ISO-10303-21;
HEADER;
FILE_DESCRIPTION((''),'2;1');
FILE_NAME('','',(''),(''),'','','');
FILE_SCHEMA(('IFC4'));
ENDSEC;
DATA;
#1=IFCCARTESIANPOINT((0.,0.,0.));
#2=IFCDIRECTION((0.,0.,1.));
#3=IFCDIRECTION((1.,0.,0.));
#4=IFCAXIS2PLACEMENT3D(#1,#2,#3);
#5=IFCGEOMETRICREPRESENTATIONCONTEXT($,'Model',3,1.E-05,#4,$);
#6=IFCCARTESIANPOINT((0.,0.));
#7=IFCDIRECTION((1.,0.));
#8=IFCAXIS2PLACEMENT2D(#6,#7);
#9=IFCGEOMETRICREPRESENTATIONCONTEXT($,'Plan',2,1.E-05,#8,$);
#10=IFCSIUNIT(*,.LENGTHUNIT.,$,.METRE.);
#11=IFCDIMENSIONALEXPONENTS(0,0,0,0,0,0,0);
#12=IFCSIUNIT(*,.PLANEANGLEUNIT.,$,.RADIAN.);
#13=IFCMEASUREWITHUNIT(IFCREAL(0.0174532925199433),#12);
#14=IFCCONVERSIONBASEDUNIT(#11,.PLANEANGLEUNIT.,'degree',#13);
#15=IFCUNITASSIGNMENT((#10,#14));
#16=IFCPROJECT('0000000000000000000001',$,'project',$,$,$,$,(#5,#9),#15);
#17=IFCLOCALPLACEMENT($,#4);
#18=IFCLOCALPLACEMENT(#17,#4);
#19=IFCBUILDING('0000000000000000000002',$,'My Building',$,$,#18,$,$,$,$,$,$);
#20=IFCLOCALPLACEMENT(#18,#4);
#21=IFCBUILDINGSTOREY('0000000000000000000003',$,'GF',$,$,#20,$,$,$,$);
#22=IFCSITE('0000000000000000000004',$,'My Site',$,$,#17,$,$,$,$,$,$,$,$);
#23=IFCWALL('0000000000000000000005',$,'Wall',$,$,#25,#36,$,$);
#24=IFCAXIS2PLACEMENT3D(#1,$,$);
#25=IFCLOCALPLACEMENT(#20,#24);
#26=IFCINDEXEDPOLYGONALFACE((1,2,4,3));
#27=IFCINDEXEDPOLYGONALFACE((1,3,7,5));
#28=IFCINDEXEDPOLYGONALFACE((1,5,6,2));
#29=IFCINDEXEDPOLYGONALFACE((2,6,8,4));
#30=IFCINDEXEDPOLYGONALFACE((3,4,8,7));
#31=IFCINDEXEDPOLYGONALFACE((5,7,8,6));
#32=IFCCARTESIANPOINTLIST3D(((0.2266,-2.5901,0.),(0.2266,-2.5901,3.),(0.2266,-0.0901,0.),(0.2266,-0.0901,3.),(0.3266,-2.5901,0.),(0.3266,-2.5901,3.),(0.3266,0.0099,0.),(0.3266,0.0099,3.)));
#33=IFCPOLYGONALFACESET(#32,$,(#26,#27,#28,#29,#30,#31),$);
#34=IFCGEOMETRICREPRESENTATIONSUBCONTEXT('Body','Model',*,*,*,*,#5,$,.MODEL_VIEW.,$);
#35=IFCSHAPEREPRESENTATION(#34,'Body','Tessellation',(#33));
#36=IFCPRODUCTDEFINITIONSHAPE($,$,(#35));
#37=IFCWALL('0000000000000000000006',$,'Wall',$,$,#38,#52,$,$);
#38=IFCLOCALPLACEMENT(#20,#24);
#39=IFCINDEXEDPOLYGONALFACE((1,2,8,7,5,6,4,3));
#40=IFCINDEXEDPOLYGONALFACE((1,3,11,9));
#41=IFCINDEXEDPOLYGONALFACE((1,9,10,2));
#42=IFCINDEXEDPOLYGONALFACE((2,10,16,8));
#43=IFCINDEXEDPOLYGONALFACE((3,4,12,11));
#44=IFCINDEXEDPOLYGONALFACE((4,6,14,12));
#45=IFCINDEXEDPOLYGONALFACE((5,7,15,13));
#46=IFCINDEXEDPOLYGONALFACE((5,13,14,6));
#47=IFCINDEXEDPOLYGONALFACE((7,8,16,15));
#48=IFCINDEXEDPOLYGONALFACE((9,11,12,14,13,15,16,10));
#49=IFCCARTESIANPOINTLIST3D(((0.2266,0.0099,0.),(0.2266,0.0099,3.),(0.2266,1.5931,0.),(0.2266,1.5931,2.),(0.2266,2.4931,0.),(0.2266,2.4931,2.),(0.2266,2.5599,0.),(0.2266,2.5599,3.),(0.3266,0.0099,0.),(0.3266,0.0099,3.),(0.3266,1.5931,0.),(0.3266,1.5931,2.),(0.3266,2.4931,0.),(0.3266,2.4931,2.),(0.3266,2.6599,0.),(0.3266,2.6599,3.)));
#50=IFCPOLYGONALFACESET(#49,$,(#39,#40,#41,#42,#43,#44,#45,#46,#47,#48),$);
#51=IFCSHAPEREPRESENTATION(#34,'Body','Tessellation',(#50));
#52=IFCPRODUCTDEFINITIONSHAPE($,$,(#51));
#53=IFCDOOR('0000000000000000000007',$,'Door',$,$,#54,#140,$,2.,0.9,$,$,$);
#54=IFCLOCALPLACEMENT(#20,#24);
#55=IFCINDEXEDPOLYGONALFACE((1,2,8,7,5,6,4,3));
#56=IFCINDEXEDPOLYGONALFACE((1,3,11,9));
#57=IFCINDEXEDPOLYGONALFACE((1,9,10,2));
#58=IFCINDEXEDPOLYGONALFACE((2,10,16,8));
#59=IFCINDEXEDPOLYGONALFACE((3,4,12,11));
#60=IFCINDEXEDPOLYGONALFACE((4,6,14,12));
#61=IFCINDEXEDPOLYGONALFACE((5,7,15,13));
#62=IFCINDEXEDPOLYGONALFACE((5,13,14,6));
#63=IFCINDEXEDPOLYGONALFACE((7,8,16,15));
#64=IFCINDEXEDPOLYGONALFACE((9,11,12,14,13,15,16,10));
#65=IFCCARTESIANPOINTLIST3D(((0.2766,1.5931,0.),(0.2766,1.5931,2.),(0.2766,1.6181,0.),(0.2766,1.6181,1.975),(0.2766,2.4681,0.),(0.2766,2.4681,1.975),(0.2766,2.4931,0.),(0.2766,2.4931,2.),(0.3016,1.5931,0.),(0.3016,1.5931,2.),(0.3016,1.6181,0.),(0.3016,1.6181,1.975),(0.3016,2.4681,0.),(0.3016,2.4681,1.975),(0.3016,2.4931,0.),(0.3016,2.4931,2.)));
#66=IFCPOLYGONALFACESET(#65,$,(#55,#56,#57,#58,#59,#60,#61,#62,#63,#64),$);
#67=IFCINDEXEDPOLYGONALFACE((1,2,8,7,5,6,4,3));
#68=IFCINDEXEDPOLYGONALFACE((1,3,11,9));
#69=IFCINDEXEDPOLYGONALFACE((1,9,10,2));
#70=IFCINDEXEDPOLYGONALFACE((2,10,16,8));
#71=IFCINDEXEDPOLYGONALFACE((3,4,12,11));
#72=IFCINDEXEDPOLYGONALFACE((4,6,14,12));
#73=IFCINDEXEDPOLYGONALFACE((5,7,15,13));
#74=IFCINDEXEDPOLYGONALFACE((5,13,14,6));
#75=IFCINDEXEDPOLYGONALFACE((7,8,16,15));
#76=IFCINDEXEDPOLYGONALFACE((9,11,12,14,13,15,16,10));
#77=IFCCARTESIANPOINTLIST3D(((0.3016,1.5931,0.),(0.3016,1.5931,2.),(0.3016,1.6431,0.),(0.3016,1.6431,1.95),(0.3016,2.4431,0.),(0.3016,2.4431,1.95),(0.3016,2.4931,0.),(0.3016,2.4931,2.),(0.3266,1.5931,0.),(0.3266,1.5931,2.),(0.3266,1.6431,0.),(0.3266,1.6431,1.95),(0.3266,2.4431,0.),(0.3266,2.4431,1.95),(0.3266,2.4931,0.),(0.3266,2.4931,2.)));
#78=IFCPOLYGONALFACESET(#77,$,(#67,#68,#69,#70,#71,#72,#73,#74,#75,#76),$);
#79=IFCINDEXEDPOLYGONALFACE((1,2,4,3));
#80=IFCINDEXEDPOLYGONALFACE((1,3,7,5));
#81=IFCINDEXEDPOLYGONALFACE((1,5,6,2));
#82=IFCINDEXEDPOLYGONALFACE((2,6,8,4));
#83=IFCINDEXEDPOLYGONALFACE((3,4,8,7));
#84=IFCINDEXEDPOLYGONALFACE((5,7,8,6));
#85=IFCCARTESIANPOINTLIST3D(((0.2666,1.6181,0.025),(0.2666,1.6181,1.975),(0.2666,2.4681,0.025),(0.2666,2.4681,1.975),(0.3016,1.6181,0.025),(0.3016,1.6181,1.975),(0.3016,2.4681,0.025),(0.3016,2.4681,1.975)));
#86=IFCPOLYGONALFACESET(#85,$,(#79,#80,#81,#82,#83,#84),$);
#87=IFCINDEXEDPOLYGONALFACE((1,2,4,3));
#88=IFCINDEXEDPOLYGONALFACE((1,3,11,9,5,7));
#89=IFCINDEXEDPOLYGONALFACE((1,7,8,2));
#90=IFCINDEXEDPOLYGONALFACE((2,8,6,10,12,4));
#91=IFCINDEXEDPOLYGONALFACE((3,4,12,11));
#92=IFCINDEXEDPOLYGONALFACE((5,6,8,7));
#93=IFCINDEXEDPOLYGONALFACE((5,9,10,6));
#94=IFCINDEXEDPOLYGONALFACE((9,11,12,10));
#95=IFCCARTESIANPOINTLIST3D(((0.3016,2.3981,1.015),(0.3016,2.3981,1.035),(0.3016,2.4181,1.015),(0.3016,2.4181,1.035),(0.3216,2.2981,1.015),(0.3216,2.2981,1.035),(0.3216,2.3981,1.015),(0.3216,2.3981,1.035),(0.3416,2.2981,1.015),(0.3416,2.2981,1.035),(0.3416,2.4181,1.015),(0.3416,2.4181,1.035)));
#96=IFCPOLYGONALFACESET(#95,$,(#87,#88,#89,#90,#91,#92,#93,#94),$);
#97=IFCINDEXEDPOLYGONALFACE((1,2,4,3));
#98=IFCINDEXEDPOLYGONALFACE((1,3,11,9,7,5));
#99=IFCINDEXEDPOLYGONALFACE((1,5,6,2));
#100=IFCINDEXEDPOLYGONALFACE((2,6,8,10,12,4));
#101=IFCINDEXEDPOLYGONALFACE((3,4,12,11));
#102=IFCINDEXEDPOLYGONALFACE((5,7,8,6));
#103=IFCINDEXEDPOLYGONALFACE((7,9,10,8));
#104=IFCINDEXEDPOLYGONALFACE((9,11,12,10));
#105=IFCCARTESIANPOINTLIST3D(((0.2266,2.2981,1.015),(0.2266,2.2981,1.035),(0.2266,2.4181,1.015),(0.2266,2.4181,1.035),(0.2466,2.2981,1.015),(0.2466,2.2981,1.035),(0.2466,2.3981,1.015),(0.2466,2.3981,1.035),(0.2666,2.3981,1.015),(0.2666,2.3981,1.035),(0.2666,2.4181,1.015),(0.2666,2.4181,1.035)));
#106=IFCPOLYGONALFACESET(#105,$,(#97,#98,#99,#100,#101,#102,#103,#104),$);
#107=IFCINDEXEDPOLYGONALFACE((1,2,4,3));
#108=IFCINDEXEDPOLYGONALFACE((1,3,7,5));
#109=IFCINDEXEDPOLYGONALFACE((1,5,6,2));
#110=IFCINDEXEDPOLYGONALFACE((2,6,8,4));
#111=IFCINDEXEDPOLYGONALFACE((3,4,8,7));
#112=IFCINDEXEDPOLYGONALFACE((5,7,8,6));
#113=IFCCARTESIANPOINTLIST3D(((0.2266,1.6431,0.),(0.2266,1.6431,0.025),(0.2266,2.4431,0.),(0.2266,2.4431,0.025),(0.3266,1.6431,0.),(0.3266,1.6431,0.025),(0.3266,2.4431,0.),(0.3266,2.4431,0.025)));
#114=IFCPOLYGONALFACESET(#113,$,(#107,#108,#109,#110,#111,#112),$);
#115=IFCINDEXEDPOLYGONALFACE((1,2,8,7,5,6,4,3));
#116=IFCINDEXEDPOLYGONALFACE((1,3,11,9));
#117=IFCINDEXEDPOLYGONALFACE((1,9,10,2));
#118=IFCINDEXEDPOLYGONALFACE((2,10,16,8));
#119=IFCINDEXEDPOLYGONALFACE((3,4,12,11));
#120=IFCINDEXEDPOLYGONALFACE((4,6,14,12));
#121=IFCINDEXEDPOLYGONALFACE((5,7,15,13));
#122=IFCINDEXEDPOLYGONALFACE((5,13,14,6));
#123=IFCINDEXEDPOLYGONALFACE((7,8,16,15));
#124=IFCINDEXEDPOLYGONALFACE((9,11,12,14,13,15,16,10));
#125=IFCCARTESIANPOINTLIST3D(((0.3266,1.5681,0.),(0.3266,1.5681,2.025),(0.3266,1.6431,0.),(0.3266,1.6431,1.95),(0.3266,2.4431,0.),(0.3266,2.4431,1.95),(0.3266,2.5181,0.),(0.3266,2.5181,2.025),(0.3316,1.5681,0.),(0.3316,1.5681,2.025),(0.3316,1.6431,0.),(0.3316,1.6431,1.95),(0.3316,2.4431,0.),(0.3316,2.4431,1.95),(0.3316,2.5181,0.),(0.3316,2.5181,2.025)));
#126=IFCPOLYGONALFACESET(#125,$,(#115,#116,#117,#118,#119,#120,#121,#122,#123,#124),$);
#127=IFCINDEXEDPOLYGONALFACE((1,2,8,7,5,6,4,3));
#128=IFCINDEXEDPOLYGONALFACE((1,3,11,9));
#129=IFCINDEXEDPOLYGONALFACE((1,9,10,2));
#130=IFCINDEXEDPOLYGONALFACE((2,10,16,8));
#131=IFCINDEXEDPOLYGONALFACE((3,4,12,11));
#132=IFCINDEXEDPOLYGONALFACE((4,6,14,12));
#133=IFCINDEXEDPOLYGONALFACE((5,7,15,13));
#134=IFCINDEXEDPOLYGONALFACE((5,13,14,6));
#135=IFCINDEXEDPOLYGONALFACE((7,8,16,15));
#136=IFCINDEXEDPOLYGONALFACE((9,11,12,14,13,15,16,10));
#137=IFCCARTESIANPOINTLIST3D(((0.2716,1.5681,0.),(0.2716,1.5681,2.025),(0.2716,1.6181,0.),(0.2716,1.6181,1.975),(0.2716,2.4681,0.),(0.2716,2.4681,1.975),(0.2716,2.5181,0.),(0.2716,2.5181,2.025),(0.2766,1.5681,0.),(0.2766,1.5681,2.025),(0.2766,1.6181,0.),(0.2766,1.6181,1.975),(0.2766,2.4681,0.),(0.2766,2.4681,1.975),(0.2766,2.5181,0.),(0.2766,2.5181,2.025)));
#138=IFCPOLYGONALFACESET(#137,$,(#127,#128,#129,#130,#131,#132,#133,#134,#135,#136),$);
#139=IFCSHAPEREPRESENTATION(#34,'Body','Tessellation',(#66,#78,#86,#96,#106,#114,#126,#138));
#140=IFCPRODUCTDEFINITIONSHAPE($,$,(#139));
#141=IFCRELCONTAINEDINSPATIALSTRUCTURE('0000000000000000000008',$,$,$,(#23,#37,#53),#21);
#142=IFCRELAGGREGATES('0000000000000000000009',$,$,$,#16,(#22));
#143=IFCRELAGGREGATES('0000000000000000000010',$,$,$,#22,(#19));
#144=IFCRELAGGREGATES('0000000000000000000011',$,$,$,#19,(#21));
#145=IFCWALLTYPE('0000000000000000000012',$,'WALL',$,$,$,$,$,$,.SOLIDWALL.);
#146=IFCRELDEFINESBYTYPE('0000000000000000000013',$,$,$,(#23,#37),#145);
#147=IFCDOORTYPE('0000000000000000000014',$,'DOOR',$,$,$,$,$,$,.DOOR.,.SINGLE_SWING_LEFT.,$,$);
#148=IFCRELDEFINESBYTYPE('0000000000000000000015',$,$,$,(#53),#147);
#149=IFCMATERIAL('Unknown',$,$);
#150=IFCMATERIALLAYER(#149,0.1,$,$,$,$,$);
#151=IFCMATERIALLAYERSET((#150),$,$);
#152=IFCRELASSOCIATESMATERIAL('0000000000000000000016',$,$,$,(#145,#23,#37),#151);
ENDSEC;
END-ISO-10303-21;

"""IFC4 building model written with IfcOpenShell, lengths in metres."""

from ifc_helpers import new_model, entity, si_unit, converted_unit, frame, origin_with_axes, origin_2d_with_axis, place, context, subcontext, project, spatial, line, indexed_curve, outline, extrude, shape, source, transform, mapped, material, layer, layer_set, layer_usage, type_object, type_shapes, element, fill, save


model = new_model("IFC4")

# Units and contexts
model_context = context("Model", 3, precision=1e-05, world=origin_with_axes())
plan_context = context("Plan", 2, precision=1e-05, world=origin_2d_with_axis())
body_context_1 = subcontext(model_context, "Body", "Model", "MODEL_VIEW")
body_context_2 = subcontext(plan_context, "Body", "Plan", "PLAN_VIEW")
ifc_project = project(units=[si_unit("LENGTHUNIT", "METRE"), converted_unit("PLANEANGLEUNIT", "degree", entity("IfcReal", 0.0174532925199433), si_unit("PLANEANGLEUNIT", "RADIAN"), dimensions=[0, 0, 0, 0, 0, 0, 0])], contexts=[model_context, plan_context])

# Site, building, storey
site_placement = place(None, origin_with_axes())
site = spatial("IfcSite", under=ifc_project, at=site_placement, Name="My Site")
building_placement = place(site_placement, origin_with_axes())
building = spatial("IfcBuilding", under=site, at=building_placement, Name="My Building")
storey_placement = place(building_placement, origin_with_axes())
storey = spatial("IfcBuildingStorey", under=building, at=storey_placement, Name="GF")

# Shared definitions
ifc_material = material(Name="Unknown")

# Shared definitions
ifc_layer_1 = layer(ifc_material, 0.1)
ifc_layer_set_1 = layer_set([ifc_layer_1])
wall_type = type_object("IfcWallType", Name="WALL", PredefinedType="SOLIDWALL", material=ifc_layer_set_1)
shared_shape_1 = source(origin_with_axes(), body_context_1, "Body", "SweptSolid", [
    extrude(outline(indexed_curve([(0.0, 0.0), (0.9, 0.0), (0.9, 2.0), (0.0, 2.0)], segments=[line(1, 2, 3, 4, 1)])), frame((0.0, -0.6, 0.0), z_axis=(0.0, -1.0, 0.0), x_axis=(1.0, 0.0, 0.0)), (0.0, 0.0, -1.0), 1.2),
])
door_type = type_object("IfcDoorType", Name="DOOR", OperationType="SINGLE_SWING_LEFT", PredefinedType="DOOR")
shared_shape_2 = source(origin_with_axes(), body_context_1, "Body", "SweptSolid", [
    extrude(outline(indexed_curve([(0.0, 0.0), (0.0, 2.0), (0.9, 2.0), (0.9, 0.0), (0.875, 0.0), (0.875, 1.975), (0.025, 1.975), (0.025, 0.0)], segments=[line(1, 2, 3, 4, 5, 6, 7, 8, 1)])), frame((0.0, 0.025, 0.0), z_axis=(0.0, -1.0, 0.0), x_axis=(1.0, 0.0, 0.0)), (0.0, 0.0, -1.0), 0.025),
    extrude(outline(indexed_curve([(0.0, 0.0), (0.0, 2.0), (0.9, 2.0), (0.9, 0.0), (0.85, 0.0), (0.85, 1.95), (0.05, 1.95), (0.05, 0.0)], segments=[line(1, 2, 3, 4, 5, 6, 7, 8, 1)])), frame((0.0, 0.0, 0.0), z_axis=(0.0, -1.0, 0.0), x_axis=(1.0, 0.0, 0.0)), (0.0, 0.0, -1.0), 0.025),
    extrude(outline(indexed_curve([(0.0, 0.0), (0.85, 0.0), (0.85, 0.035), (0.0, 0.035)], segments=[line(1, 2, 3, 4, 1)])), frame((0.025, 0.025, 0.025), z_axis=(0.0, 0.0, 1.0), x_axis=(1.0, 0.0, 0.0)), (0.0, 0.0, 1.0), 1.95),
    extrude(outline(indexed_curve([(0.0, 0.0), (0.0, -0.04), (-0.12, -0.04), (-0.12, -0.02), (-0.02, -0.02), (-0.02, 0.0)], segments=[line(1, 2, 3, 4, 5, 6, 1)])), frame((0.825, 0.025, 1.015), z_axis=(0.0, 0.0, 1.0), x_axis=(1.0, 0.0, 0.0)), (0.0, 0.0, 1.0), 0.02),
    extrude(outline(indexed_curve([(0.0, 0.0), (0.0, 0.04), (-0.12, 0.04), (-0.12, 0.02), (-0.02, 0.02), (-0.02, 0.0)], segments=[line(1, 2, 3, 4, 5, 6, 1)])), frame((0.825, 0.06, 1.015), z_axis=(0.0, 0.0, 1.0), x_axis=(1.0, 0.0, 0.0)), (0.0, 0.0, 1.0), 0.02),
    extrude(outline(indexed_curve([(0.0, 0.0), (0.8, 0.0), (0.8, 0.1), (0.0, 0.1)], segments=[line(1, 2, 3, 4, 1)])), frame((0.05, 0.0, 0.0), z_axis=(0.0, 0.0, 1.0), x_axis=(1.0, 0.0, 0.0)), (0.0, 0.0, 1.0), 0.025),
    extrude(outline(indexed_curve([(0.0, 0.0), (0.0, 2.025), (0.95, 2.025), (0.95, 0.0), (0.875, 0.0), (0.875, 1.95), (0.075, 1.95), (0.075, 0.0)], segments=[line(1, 2, 3, 4, 5, 6, 7, 8, 1)])), frame((-0.025, -0.005, 0.0), z_axis=(0.0, -1.0, 0.0), x_axis=(1.0, 0.0, 0.0)), (0.0, 0.0, -1.0), 0.005),
    extrude(outline(indexed_curve([(0.0, 0.0), (0.0, 2.025), (0.95, 2.025), (0.95, 0.0), (0.9, 0.0), (0.9, 1.975), (0.05, 1.975), (0.05, 0.0)], segments=[line(1, 2, 3, 4, 5, 6, 7, 8, 1)])), frame((-0.025, 0.05, 0.0), z_axis=(0.0, -1.0, 0.0), x_axis=(1.0, 0.0, 0.0)), (0.0, 0.0, -1.0), 0.005),
])
shared_shape_3 = source(origin_with_axes(), body_context_2, "Body", "Curve2D", [
    entity("IfcIndexedPolyCurve", entity("IfcCartesianPointList2D", [[0.0, 0.0], [0.0, 0.05], [0.025, 0.05], [0.025, 0.025], [0.05, 0.025], [0.05, 0.0]]), [entity("IfcLineIndex", [1, 2, 3, 4, 5, 6, 1])]),
    entity("IfcIndexedPolyCurve", entity("IfcCartesianPointList2D", [[0.9, 0.0], [0.9, 0.05], [0.875, 0.05], [0.875, 0.025], [0.85, 0.025], [0.85, 0.0]]), [entity("IfcLineIndex", [1, 2, 3, 4, 5, 6, 1])]),
    entity("IfcTrimmedCurve", entity("IfcEllipse", entity("IfcAxis2Placement2D", entity("IfcCartesianPoint", [0.06, 0.05]), entity("IfcDirection", [1.0, 0.0])), 0.815, 0.85), [entity("IfcCartesianPoint", [0.875, 0.05])], [entity("IfcCartesianPoint", [0.06, 0.9])], True, "CARTESIAN"),
    entity("IfcIndexedPolyCurve", entity("IfcCartesianPointList2D", [[0.025, 0.05], [0.06, 0.05], [0.06, 0.9], [0.025, 0.9]]), [entity("IfcLineIndex", [1, 2, 3, 4, 1])]),
])
type_shapes(door_type, [shared_shape_2, shared_shape_3])

# Wall
ifc_layer_usage_1 = layer_usage(ifc_layer_set_1, "AXIS2", "POSITIVE", 0.0)
wall_1_placement = place(storey_placement, frame((0.2266, -0.0901, 0.0), z_axis=(0.0, 0.0, 1.0), x_axis=(0.0, -1.0, 0.0)))
element("IfcWall", 1, at=wall_1_placement, inside=storey, type_object=wall_type, material=ifc_layer_usage_1, Name="Wall", context=body_context_1, shape_type="SweptSolid", body=[
    extrude(outline(indexed_curve([(0.0, 0.0), (-0.1, 0.1), (2.5, 0.1), (2.5, 0.0)], segments=[line(1, 2, 3, 4, 1)])), origin_with_axes(), (0.0, 0.0, 1.0), 3.0),
])

# Wall, opening, door
ifc_layer_usage_2 = layer_usage(ifc_layer_set_1, "AXIS2", "POSITIVE", 0.0)
wall_2_placement = place(storey_placement, frame((0.3266, 0.0099, 0.0), z_axis=(0.0, 0.0, 1.0), x_axis=(0.0, 1.0, 0.0)))
wall_2 = element("IfcWall", 2, at=wall_2_placement, inside=storey, type_object=wall_type, material=ifc_layer_usage_2, Name="Wall", context=body_context_1, shape_type="SweptSolid", body=[
    extrude(outline(indexed_curve([(0.0, 0.0), (0.0, 0.1), (2.55, 0.1), (2.65, 0.0)], segments=[line(1, 2, 3, 4, 1)])), origin_with_axes(), (0.0, 0.0, 1.0), 3.0),
])
opening_1_placement = place(wall_2_placement, frame((1.5832, 0.0, 0.0), z_axis=(0.0, 0.0, 1.0), x_axis=(1.0, 0.0, 0.0)))
opening_1 = element("IfcOpeningElement", 3, at=opening_1_placement, cuts=wall_2, PredefinedType="OPENING", context=body_context_1, shape_type="MappedRepresentation", body=[
    mapped(shared_shape_1, transform((0.0, 0.0, 0.0), x_axis=(1.0, 0.0, 0.0), y_axis=(0.0, 1.0, 0.0), z_axis=(0.0, 0.0, 1.0), scale=1.0)),
])
door_1_placement = place(opening_1_placement, frame((0.0, 0.0, 0.0), z_axis=(0.0, 0.0, 1.0), x_axis=(1.0, 0.0, 0.0)))
door_1 = element("IfcDoor", 4, at=door_1_placement, inside=storey, type_object=door_type, Name="Door", OverallHeight=2.0, OverallWidth=0.9, shapes=[
    shape(body_context_1, "Body", "MappedRepresentation", [mapped(shared_shape_2, transform((0.0, 0.0, 0.0), x_axis=(1.0, 0.0, 0.0), y_axis=(0.0, 1.0, 0.0), z_axis=(0.0, 0.0, 1.0), scale=1.0))]),
    shape(body_context_2, "Body", "MappedRepresentation", [mapped(shared_shape_3, transform((0.0, 0.0, 0.0), x_axis=(1.0, 0.0, 0.0), y_axis=(0.0, 1.0, 0.0), z_axis=(0.0, 0.0, 1.0), scale=1.0))]),
])
fill(opening_1, door_1)

save(model, "model.ifc")
